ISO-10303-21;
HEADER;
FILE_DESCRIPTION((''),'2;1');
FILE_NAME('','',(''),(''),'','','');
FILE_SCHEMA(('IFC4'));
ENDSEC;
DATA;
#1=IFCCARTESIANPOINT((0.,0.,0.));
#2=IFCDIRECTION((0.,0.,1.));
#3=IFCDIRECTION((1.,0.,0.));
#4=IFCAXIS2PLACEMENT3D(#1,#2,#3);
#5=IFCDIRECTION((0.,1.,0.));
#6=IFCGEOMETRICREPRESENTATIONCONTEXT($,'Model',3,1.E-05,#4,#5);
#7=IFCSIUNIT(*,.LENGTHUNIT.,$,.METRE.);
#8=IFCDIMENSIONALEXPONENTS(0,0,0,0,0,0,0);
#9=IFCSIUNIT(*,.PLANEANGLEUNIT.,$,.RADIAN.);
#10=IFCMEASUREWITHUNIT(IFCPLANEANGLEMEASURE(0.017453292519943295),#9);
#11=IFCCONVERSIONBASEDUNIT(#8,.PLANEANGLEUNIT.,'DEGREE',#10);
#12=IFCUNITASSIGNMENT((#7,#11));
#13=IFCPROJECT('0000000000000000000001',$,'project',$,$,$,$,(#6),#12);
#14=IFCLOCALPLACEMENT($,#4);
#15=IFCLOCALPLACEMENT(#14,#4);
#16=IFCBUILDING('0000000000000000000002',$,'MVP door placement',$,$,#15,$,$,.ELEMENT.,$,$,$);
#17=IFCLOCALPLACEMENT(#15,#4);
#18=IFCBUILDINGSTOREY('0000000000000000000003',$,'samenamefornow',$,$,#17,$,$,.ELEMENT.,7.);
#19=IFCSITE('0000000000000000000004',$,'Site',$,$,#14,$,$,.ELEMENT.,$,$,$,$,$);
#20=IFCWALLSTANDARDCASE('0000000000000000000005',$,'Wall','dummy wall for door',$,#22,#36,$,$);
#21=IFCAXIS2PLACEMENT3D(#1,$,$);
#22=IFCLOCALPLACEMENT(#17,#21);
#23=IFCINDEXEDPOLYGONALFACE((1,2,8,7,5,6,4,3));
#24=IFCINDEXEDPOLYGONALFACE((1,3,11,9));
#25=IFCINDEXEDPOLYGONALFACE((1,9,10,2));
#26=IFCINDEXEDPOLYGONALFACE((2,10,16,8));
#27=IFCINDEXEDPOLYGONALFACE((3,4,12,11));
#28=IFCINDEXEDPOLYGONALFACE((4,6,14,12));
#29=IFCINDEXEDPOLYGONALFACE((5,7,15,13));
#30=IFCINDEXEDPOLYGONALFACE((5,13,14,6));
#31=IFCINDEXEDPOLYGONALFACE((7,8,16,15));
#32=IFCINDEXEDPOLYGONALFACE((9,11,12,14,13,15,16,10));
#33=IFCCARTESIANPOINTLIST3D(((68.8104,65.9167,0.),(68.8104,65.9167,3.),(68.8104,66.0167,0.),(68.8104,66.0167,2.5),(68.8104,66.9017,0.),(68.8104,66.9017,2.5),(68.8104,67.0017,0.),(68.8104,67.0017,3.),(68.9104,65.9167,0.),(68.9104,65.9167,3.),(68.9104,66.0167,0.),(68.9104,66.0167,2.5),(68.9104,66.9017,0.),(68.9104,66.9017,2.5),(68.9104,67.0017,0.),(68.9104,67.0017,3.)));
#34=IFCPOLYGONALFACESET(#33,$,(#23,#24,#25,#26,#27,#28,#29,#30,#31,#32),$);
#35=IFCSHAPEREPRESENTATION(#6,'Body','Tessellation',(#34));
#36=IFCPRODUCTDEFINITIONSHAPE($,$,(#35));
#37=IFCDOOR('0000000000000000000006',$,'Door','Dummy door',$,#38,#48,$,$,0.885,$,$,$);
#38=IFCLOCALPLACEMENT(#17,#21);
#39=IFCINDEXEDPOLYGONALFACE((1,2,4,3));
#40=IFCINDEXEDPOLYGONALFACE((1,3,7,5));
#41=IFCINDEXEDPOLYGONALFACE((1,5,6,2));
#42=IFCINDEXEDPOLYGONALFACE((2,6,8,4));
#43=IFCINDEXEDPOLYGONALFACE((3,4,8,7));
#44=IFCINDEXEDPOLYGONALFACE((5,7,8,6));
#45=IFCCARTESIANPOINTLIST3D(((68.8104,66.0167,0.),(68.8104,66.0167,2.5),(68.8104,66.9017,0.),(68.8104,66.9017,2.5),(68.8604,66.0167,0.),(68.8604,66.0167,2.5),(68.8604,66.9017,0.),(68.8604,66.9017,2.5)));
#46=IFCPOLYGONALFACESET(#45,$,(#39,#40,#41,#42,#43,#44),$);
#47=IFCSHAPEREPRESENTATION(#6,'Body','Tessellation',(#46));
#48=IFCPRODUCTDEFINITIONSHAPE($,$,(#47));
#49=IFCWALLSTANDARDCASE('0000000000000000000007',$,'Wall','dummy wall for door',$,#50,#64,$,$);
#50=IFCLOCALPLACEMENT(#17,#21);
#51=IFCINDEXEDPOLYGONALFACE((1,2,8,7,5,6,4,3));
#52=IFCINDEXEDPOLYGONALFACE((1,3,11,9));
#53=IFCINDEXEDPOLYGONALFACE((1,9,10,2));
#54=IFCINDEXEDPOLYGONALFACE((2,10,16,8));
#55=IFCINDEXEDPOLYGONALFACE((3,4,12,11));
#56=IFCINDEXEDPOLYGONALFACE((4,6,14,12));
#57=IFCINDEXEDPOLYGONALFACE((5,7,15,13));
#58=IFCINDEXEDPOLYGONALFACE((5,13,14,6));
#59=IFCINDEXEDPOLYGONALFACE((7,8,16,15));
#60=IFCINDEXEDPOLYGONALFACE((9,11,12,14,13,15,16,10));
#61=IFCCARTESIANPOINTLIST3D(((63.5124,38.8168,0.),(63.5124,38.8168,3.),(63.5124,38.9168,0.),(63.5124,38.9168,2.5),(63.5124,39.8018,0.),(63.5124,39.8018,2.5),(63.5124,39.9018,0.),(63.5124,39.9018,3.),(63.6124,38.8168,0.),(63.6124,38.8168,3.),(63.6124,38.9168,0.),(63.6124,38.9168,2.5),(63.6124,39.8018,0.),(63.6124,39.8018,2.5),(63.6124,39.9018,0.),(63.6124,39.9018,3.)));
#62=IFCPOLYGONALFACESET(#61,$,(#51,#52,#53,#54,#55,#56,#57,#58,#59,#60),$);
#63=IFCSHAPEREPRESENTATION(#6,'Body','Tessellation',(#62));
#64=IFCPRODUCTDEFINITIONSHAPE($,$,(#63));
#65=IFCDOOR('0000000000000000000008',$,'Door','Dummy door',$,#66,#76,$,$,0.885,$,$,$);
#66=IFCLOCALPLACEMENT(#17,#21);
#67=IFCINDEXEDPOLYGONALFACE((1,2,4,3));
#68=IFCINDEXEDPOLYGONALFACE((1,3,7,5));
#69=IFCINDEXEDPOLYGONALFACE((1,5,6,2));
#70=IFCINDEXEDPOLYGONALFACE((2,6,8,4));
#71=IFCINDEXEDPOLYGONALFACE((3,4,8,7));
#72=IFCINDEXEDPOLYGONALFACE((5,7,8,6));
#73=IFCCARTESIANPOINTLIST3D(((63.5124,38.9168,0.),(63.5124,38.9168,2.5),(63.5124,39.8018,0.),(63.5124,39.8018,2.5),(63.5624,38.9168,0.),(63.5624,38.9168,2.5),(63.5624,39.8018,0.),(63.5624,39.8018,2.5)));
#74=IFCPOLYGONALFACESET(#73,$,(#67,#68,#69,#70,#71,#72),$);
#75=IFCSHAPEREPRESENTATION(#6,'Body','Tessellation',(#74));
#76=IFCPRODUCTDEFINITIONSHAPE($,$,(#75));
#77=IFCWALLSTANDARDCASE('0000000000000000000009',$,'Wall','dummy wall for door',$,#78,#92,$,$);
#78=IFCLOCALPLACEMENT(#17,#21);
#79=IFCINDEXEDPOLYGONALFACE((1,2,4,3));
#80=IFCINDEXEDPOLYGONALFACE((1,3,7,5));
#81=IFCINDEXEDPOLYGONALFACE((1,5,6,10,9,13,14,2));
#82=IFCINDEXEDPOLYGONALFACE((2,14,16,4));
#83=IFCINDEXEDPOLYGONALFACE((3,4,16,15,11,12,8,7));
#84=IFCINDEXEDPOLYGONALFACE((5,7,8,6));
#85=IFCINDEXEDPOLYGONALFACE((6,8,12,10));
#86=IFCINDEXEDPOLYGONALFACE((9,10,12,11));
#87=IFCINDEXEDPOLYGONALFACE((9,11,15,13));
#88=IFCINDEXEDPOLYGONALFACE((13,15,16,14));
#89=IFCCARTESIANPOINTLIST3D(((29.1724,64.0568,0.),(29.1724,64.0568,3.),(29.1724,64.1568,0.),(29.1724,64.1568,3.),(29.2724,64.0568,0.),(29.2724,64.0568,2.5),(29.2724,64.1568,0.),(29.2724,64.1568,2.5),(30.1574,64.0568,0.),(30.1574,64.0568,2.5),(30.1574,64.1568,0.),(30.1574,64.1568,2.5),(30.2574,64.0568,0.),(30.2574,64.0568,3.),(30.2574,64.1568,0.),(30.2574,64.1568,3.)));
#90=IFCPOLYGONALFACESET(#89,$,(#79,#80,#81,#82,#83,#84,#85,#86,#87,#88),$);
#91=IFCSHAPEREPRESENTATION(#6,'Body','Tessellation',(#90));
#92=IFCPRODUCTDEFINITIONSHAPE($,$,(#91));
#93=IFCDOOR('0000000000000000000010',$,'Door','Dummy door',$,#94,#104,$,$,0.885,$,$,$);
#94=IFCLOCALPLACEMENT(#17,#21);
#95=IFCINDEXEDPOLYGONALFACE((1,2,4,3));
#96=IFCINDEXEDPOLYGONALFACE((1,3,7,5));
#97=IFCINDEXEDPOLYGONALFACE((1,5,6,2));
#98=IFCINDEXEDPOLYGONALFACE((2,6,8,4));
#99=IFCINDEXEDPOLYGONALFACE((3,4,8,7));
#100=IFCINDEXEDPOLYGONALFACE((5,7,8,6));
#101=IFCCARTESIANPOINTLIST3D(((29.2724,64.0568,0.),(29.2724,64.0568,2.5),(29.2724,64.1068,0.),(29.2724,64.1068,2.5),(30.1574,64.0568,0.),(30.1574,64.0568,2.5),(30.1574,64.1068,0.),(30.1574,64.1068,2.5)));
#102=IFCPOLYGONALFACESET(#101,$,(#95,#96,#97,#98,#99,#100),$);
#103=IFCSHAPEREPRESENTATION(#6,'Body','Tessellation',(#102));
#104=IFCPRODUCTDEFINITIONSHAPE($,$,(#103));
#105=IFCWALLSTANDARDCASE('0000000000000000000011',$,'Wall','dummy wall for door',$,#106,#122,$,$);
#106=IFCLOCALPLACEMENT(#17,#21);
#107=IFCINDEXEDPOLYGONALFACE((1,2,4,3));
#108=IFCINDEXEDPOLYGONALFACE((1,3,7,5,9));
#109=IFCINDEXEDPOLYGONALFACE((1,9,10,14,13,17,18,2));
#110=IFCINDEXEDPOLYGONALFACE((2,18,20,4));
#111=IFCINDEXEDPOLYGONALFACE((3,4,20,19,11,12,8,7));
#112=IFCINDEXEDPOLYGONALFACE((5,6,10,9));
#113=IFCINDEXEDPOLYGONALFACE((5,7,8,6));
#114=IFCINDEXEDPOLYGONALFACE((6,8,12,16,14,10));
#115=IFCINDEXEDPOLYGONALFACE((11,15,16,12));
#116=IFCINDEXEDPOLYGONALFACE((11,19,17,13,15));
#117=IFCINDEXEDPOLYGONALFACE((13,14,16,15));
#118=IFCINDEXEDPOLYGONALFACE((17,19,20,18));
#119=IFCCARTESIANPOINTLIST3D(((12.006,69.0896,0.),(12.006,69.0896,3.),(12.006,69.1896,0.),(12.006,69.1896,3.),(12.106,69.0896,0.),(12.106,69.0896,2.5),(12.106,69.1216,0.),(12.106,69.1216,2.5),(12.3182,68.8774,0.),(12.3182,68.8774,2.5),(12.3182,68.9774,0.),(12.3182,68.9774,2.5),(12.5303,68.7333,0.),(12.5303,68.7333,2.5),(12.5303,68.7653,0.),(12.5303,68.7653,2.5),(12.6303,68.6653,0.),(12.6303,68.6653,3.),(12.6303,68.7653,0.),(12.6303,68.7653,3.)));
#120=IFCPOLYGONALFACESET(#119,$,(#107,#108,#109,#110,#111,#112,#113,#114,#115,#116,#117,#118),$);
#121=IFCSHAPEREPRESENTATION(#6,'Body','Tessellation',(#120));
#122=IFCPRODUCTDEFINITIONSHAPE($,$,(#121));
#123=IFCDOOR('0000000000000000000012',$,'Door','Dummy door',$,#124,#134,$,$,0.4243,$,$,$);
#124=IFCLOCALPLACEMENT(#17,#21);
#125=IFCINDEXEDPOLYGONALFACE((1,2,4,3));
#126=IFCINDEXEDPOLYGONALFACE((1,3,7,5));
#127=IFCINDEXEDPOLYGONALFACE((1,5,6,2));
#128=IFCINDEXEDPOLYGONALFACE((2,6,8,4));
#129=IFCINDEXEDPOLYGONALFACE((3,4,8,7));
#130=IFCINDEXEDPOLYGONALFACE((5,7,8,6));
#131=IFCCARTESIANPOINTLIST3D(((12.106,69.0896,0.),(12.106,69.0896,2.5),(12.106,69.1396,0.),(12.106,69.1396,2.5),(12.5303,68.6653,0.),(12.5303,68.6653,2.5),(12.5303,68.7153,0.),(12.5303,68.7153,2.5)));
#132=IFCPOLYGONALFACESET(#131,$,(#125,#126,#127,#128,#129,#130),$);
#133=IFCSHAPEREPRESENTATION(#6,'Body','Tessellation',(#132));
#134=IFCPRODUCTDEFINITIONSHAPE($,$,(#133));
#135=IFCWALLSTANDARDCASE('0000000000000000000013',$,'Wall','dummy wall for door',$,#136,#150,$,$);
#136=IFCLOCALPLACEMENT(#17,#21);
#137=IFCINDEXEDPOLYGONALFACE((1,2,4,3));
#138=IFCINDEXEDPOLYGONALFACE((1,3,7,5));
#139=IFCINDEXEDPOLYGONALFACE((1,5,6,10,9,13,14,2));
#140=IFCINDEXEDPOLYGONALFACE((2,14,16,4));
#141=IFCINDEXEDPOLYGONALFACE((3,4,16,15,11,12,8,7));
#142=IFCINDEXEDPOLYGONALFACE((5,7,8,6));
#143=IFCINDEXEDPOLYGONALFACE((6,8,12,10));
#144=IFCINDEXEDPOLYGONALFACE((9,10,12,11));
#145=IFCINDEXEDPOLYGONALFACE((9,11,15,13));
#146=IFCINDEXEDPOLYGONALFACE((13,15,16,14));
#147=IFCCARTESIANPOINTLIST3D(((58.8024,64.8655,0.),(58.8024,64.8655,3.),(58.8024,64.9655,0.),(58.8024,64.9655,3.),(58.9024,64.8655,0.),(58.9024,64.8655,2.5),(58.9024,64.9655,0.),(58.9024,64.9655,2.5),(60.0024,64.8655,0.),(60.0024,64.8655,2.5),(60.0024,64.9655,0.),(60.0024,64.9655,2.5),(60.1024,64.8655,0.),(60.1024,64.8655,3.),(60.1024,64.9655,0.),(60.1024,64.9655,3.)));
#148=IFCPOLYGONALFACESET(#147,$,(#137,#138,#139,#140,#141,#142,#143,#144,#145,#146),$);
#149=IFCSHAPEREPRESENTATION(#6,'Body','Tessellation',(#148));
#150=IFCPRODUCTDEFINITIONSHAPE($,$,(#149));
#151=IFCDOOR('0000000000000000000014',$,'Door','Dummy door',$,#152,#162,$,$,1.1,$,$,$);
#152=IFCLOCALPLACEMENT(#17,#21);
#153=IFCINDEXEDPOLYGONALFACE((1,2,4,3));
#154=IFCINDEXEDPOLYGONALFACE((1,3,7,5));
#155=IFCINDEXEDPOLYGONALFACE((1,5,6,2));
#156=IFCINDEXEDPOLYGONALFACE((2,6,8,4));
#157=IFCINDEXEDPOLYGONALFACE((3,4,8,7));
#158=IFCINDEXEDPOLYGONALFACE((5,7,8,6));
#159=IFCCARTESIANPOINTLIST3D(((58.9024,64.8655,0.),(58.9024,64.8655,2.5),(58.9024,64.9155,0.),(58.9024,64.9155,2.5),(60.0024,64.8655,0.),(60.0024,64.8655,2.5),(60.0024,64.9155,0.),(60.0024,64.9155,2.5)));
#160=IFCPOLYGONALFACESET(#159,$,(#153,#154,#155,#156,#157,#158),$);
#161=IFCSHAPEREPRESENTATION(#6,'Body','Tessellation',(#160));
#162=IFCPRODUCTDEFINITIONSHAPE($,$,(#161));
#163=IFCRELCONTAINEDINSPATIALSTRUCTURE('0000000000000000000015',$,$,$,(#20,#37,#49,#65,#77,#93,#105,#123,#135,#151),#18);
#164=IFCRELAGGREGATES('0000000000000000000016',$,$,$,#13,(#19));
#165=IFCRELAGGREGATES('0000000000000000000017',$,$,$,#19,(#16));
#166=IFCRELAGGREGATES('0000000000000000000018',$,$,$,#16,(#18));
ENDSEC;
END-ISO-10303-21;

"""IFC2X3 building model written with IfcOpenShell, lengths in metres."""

from ifc_helpers import new_model, entity, si_unit, converted_unit, direction, origin_with_axes, place, context, project, spatial, polyline, outline, extrude, element, fill, save


model = new_model("IFC2X3")

# Units and contexts
model_context = context("Model", 3, precision=1e-05, world=origin_with_axes(), true_north=direction((0.0, 1.0, 0.0)))
ifc_project = project(units=[si_unit("LENGTHUNIT", "METRE"), converted_unit("PLANEANGLEUNIT", "DEGREE", entity("IfcPlaneAngleMeasure", 0.017453292519943295), si_unit("PLANEANGLEUNIT", "RADIAN"), dimensions=[0, 0, 0, 0, 0, 0, 0])], contexts=[model_context])

# Site, building, storey
site_placement = place(None, origin_with_axes())
site = spatial("IfcSite", under=ifc_project, at=site_placement, Name="Site", CompositionType="ELEMENT")
building_placement = place(site_placement, origin_with_axes())
building = spatial("IfcBuilding", under=site, at=building_placement, Name="MVP door placement", CompositionType="ELEMENT")
storey_placement = place(building_placement, origin_with_axes())
storey = spatial("IfcBuildingStorey", under=building, at=storey_placement, Name="samenamefornow", CompositionType="ELEMENT", Elevation=7.0)

# Walls, openings, doors
wall_1_placement = place(storey_placement, origin_with_axes())
wall_1 = element("IfcWallStandardCase", 1, at=wall_1_placement, inside=storey, Name="Wall", Description="dummy wall for door", context=model_context, shape_type="SweptSolid", body=[
    extrude(outline(polyline([(68.8104, 67.0017, 0.0), (68.8104, 65.9167, 0.0), (68.9104, 65.9167, 0.0), (68.9104, 67.0017, 0.0), (68.8104, 67.0017, 0.0)])), origin_with_axes(), (0.0, 0.0, 1.0), 3.0),
])
opening_1_placement = place(wall_1_placement, origin_with_axes())
opening_1 = element("IfcOpeningElement", 2, at=opening_1_placement, cuts=wall_1, context=model_context, shape_type="SweptSolid", body=[
    extrude(outline(polyline([(68.8104, 66.9017, 0.0), (68.8104, 66.0167, 0.0), (68.9104, 66.0167, 0.0), (68.9104, 66.9017, 0.0), (68.8104, 66.9017, 0.0)])), origin_with_axes(), (0.0, 0.0, 1.0), 2.5),
])
door_1_placement = place(opening_1_placement, origin_with_axes())
door_1 = element("IfcDoor", 3, at=door_1_placement, inside=storey, Name="Door", Description="Dummy door", OverallWidth=0.885, context=model_context, shape_type="SweptSolid", body=[
    extrude(outline(polyline([(68.8104, 66.9017, 0.0), (68.8104, 66.0167, 0.0), (68.8604, 66.0167, 0.0), (68.8604, 66.9017, 0.0), (68.8104, 66.9017, 0.0)])), origin_with_axes(), (0.0, 0.0, 1.0), 2.5),
])
fill(opening_1, door_1)
wall_2_placement = place(storey_placement, origin_with_axes())
wall_2 = element("IfcWallStandardCase", 4, at=wall_2_placement, inside=storey, Name="Wall", Description="dummy wall for door", context=model_context, shape_type="SweptSolid", body=[
    extrude(outline(polyline([(63.5124, 39.9018, 0.0), (63.5124, 38.8168, 0.0), (63.6124, 38.8168, 0.0), (63.6124, 39.9018, 0.0), (63.5124, 39.9018, 0.0)])), origin_with_axes(), (0.0, 0.0, 1.0), 3.0),
])
opening_2_placement = place(wall_2_placement, origin_with_axes())
opening_2 = element("IfcOpeningElement", 5, at=opening_2_placement, cuts=wall_2, context=model_context, shape_type="SweptSolid", body=[
    extrude(outline(polyline([(63.5124, 39.8018, 0.0), (63.5124, 38.9168, 0.0), (63.6124, 38.9168, 0.0), (63.6124, 39.8018, 0.0), (63.5124, 39.8018, 0.0)])), origin_with_axes(), (0.0, 0.0, 1.0), 2.5),
])
door_2_placement = place(opening_2_placement, origin_with_axes())
door_2 = element("IfcDoor", 6, at=door_2_placement, inside=storey, Name="Door", Description="Dummy door", OverallWidth=0.885, context=model_context, shape_type="SweptSolid", body=[
    extrude(outline(polyline([(63.5124, 39.8018, 0.0), (63.5124, 38.9168, 0.0), (63.5624, 38.9168, 0.0), (63.5624, 39.8018, 0.0), (63.5124, 39.8018, 0.0)])), origin_with_axes(), (0.0, 0.0, 1.0), 2.5),
])
fill(opening_2, door_2)
wall_3_placement = place(storey_placement, origin_with_axes())
wall_3 = element("IfcWallStandardCase", 7, at=wall_3_placement, inside=storey, Name="Wall", Description="dummy wall for door", context=model_context, shape_type="SweptSolid", body=[
    extrude(outline(polyline([(30.2574, 64.0568, 0.0), (29.1724, 64.0568, 0.0), (29.1724, 64.1568, 0.0), (30.2574, 64.1568, 0.0), (30.2574, 64.0568, 0.0)])), origin_with_axes(), (0.0, 0.0, 1.0), 3.0),
])
opening_3_placement = place(wall_3_placement, origin_with_axes())
opening_3 = element("IfcOpeningElement", 8, at=opening_3_placement, cuts=wall_3, context=model_context, shape_type="SweptSolid", body=[
    extrude(outline(polyline([(30.1574, 64.0568, 0.0), (29.2724, 64.0568, 0.0), (29.2724, 64.1568, 0.0), (30.1574, 64.1568, 0.0), (30.1574, 64.0568, 0.0)])), origin_with_axes(), (0.0, 0.0, 1.0), 2.5),
])
door_3_placement = place(opening_3_placement, origin_with_axes())
door_3 = element("IfcDoor", 9, at=door_3_placement, inside=storey, Name="Door", Description="Dummy door", OverallWidth=0.885, context=model_context, shape_type="SweptSolid", body=[
    extrude(outline(polyline([(30.1574, 64.0568, 0.0), (29.2724, 64.0568, 0.0), (29.2724, 64.1068, 0.0), (30.1574, 64.1068, 0.0), (30.1574, 64.0568, 0.0)])), origin_with_axes(), (0.0, 0.0, 1.0), 2.5),
])
fill(opening_3, door_3)
wall_4_placement = place(storey_placement, origin_with_axes())
wall_4 = element("IfcWallStandardCase", 10, at=wall_4_placement, inside=storey, Name="Wall", Description="dummy wall for door", context=model_context, shape_type="SweptSolid", body=[
    extrude(outline(polyline([(12.006, 69.0896, 0.0), (12.6303, 68.6653, 0.0), (12.6303, 68.7653, 0.0), (12.006, 69.1896, 0.0), (12.006, 69.0896, 0.0)])), origin_with_axes(), (0.0, 0.0, 1.0), 3.0),
])
opening_4_placement = place(wall_4_placement, origin_with_axes())
opening_4 = element("IfcOpeningElement", 11, at=opening_4_placement, cuts=wall_4, context=model_context, shape_type="SweptSolid", body=[
    extrude(outline(polyline([(12.106, 69.0896, 0.0), (12.5303, 68.6653, 0.0), (12.5303, 68.7653, 0.0), (12.106, 69.1896, 0.0), (12.106, 69.0896, 0.0)])), origin_with_axes(), (0.0, 0.0, 1.0), 2.5),
])
door_4_placement = place(opening_4_placement, origin_with_axes())
door_4 = element("IfcDoor", 12, at=door_4_placement, inside=storey, Name="Door", Description="Dummy door", OverallWidth=0.4243, context=model_context, shape_type="SweptSolid", body=[
    extrude(outline(polyline([(12.106, 69.0896, 0.0), (12.5303, 68.6653, 0.0), (12.5303, 68.7153, 0.0), (12.106, 69.1396, 0.0), (12.106, 69.0896, 0.0)])), origin_with_axes(), (0.0, 0.0, 1.0), 2.5),
])
fill(opening_4, door_4)
wall_5_placement = place(storey_placement, origin_with_axes())
wall_5 = element("IfcWallStandardCase", 13, at=wall_5_placement, inside=storey, Name="Wall", Description="dummy wall for door", context=model_context, shape_type="SweptSolid", body=[
    extrude(outline(polyline([(58.8024, 64.8655, 0.0), (60.1024, 64.8655, 0.0), (60.1024, 64.9655, 0.0), (58.8024, 64.9655, 0.0), (58.8024, 64.8655, 0.0)])), origin_with_axes(), (0.0, 0.0, 1.0), 3.0),
])
opening_5_placement = place(wall_5_placement, origin_with_axes())
opening_5 = element("IfcOpeningElement", 14, at=opening_5_placement, cuts=wall_5, context=model_context, shape_type="SweptSolid", body=[
    extrude(outline(polyline([(58.9024, 64.8655, 0.0), (60.0024, 64.8655, 0.0), (60.0024, 64.9655, 0.0), (58.9024, 64.9655, 0.0), (58.9024, 64.8655, 0.0)])), origin_with_axes(), (0.0, 0.0, 1.0), 2.5),
])
door_5_placement = place(opening_5_placement, origin_with_axes())
door_5 = element("IfcDoor", 15, at=door_5_placement, inside=storey, Name="Door", Description="Dummy door", OverallWidth=1.1, context=model_context, shape_type="SweptSolid", body=[
    extrude(outline(polyline([(58.9024, 64.8655, 0.0), (60.0024, 64.8655, 0.0), (60.0024, 64.9155, 0.0), (58.9024, 64.9155, 0.0), (58.9024, 64.8655, 0.0)])), origin_with_axes(), (0.0, 0.0, 1.0), 2.5),
])
fill(opening_5, door_5)

save(model, "model.ifc")
